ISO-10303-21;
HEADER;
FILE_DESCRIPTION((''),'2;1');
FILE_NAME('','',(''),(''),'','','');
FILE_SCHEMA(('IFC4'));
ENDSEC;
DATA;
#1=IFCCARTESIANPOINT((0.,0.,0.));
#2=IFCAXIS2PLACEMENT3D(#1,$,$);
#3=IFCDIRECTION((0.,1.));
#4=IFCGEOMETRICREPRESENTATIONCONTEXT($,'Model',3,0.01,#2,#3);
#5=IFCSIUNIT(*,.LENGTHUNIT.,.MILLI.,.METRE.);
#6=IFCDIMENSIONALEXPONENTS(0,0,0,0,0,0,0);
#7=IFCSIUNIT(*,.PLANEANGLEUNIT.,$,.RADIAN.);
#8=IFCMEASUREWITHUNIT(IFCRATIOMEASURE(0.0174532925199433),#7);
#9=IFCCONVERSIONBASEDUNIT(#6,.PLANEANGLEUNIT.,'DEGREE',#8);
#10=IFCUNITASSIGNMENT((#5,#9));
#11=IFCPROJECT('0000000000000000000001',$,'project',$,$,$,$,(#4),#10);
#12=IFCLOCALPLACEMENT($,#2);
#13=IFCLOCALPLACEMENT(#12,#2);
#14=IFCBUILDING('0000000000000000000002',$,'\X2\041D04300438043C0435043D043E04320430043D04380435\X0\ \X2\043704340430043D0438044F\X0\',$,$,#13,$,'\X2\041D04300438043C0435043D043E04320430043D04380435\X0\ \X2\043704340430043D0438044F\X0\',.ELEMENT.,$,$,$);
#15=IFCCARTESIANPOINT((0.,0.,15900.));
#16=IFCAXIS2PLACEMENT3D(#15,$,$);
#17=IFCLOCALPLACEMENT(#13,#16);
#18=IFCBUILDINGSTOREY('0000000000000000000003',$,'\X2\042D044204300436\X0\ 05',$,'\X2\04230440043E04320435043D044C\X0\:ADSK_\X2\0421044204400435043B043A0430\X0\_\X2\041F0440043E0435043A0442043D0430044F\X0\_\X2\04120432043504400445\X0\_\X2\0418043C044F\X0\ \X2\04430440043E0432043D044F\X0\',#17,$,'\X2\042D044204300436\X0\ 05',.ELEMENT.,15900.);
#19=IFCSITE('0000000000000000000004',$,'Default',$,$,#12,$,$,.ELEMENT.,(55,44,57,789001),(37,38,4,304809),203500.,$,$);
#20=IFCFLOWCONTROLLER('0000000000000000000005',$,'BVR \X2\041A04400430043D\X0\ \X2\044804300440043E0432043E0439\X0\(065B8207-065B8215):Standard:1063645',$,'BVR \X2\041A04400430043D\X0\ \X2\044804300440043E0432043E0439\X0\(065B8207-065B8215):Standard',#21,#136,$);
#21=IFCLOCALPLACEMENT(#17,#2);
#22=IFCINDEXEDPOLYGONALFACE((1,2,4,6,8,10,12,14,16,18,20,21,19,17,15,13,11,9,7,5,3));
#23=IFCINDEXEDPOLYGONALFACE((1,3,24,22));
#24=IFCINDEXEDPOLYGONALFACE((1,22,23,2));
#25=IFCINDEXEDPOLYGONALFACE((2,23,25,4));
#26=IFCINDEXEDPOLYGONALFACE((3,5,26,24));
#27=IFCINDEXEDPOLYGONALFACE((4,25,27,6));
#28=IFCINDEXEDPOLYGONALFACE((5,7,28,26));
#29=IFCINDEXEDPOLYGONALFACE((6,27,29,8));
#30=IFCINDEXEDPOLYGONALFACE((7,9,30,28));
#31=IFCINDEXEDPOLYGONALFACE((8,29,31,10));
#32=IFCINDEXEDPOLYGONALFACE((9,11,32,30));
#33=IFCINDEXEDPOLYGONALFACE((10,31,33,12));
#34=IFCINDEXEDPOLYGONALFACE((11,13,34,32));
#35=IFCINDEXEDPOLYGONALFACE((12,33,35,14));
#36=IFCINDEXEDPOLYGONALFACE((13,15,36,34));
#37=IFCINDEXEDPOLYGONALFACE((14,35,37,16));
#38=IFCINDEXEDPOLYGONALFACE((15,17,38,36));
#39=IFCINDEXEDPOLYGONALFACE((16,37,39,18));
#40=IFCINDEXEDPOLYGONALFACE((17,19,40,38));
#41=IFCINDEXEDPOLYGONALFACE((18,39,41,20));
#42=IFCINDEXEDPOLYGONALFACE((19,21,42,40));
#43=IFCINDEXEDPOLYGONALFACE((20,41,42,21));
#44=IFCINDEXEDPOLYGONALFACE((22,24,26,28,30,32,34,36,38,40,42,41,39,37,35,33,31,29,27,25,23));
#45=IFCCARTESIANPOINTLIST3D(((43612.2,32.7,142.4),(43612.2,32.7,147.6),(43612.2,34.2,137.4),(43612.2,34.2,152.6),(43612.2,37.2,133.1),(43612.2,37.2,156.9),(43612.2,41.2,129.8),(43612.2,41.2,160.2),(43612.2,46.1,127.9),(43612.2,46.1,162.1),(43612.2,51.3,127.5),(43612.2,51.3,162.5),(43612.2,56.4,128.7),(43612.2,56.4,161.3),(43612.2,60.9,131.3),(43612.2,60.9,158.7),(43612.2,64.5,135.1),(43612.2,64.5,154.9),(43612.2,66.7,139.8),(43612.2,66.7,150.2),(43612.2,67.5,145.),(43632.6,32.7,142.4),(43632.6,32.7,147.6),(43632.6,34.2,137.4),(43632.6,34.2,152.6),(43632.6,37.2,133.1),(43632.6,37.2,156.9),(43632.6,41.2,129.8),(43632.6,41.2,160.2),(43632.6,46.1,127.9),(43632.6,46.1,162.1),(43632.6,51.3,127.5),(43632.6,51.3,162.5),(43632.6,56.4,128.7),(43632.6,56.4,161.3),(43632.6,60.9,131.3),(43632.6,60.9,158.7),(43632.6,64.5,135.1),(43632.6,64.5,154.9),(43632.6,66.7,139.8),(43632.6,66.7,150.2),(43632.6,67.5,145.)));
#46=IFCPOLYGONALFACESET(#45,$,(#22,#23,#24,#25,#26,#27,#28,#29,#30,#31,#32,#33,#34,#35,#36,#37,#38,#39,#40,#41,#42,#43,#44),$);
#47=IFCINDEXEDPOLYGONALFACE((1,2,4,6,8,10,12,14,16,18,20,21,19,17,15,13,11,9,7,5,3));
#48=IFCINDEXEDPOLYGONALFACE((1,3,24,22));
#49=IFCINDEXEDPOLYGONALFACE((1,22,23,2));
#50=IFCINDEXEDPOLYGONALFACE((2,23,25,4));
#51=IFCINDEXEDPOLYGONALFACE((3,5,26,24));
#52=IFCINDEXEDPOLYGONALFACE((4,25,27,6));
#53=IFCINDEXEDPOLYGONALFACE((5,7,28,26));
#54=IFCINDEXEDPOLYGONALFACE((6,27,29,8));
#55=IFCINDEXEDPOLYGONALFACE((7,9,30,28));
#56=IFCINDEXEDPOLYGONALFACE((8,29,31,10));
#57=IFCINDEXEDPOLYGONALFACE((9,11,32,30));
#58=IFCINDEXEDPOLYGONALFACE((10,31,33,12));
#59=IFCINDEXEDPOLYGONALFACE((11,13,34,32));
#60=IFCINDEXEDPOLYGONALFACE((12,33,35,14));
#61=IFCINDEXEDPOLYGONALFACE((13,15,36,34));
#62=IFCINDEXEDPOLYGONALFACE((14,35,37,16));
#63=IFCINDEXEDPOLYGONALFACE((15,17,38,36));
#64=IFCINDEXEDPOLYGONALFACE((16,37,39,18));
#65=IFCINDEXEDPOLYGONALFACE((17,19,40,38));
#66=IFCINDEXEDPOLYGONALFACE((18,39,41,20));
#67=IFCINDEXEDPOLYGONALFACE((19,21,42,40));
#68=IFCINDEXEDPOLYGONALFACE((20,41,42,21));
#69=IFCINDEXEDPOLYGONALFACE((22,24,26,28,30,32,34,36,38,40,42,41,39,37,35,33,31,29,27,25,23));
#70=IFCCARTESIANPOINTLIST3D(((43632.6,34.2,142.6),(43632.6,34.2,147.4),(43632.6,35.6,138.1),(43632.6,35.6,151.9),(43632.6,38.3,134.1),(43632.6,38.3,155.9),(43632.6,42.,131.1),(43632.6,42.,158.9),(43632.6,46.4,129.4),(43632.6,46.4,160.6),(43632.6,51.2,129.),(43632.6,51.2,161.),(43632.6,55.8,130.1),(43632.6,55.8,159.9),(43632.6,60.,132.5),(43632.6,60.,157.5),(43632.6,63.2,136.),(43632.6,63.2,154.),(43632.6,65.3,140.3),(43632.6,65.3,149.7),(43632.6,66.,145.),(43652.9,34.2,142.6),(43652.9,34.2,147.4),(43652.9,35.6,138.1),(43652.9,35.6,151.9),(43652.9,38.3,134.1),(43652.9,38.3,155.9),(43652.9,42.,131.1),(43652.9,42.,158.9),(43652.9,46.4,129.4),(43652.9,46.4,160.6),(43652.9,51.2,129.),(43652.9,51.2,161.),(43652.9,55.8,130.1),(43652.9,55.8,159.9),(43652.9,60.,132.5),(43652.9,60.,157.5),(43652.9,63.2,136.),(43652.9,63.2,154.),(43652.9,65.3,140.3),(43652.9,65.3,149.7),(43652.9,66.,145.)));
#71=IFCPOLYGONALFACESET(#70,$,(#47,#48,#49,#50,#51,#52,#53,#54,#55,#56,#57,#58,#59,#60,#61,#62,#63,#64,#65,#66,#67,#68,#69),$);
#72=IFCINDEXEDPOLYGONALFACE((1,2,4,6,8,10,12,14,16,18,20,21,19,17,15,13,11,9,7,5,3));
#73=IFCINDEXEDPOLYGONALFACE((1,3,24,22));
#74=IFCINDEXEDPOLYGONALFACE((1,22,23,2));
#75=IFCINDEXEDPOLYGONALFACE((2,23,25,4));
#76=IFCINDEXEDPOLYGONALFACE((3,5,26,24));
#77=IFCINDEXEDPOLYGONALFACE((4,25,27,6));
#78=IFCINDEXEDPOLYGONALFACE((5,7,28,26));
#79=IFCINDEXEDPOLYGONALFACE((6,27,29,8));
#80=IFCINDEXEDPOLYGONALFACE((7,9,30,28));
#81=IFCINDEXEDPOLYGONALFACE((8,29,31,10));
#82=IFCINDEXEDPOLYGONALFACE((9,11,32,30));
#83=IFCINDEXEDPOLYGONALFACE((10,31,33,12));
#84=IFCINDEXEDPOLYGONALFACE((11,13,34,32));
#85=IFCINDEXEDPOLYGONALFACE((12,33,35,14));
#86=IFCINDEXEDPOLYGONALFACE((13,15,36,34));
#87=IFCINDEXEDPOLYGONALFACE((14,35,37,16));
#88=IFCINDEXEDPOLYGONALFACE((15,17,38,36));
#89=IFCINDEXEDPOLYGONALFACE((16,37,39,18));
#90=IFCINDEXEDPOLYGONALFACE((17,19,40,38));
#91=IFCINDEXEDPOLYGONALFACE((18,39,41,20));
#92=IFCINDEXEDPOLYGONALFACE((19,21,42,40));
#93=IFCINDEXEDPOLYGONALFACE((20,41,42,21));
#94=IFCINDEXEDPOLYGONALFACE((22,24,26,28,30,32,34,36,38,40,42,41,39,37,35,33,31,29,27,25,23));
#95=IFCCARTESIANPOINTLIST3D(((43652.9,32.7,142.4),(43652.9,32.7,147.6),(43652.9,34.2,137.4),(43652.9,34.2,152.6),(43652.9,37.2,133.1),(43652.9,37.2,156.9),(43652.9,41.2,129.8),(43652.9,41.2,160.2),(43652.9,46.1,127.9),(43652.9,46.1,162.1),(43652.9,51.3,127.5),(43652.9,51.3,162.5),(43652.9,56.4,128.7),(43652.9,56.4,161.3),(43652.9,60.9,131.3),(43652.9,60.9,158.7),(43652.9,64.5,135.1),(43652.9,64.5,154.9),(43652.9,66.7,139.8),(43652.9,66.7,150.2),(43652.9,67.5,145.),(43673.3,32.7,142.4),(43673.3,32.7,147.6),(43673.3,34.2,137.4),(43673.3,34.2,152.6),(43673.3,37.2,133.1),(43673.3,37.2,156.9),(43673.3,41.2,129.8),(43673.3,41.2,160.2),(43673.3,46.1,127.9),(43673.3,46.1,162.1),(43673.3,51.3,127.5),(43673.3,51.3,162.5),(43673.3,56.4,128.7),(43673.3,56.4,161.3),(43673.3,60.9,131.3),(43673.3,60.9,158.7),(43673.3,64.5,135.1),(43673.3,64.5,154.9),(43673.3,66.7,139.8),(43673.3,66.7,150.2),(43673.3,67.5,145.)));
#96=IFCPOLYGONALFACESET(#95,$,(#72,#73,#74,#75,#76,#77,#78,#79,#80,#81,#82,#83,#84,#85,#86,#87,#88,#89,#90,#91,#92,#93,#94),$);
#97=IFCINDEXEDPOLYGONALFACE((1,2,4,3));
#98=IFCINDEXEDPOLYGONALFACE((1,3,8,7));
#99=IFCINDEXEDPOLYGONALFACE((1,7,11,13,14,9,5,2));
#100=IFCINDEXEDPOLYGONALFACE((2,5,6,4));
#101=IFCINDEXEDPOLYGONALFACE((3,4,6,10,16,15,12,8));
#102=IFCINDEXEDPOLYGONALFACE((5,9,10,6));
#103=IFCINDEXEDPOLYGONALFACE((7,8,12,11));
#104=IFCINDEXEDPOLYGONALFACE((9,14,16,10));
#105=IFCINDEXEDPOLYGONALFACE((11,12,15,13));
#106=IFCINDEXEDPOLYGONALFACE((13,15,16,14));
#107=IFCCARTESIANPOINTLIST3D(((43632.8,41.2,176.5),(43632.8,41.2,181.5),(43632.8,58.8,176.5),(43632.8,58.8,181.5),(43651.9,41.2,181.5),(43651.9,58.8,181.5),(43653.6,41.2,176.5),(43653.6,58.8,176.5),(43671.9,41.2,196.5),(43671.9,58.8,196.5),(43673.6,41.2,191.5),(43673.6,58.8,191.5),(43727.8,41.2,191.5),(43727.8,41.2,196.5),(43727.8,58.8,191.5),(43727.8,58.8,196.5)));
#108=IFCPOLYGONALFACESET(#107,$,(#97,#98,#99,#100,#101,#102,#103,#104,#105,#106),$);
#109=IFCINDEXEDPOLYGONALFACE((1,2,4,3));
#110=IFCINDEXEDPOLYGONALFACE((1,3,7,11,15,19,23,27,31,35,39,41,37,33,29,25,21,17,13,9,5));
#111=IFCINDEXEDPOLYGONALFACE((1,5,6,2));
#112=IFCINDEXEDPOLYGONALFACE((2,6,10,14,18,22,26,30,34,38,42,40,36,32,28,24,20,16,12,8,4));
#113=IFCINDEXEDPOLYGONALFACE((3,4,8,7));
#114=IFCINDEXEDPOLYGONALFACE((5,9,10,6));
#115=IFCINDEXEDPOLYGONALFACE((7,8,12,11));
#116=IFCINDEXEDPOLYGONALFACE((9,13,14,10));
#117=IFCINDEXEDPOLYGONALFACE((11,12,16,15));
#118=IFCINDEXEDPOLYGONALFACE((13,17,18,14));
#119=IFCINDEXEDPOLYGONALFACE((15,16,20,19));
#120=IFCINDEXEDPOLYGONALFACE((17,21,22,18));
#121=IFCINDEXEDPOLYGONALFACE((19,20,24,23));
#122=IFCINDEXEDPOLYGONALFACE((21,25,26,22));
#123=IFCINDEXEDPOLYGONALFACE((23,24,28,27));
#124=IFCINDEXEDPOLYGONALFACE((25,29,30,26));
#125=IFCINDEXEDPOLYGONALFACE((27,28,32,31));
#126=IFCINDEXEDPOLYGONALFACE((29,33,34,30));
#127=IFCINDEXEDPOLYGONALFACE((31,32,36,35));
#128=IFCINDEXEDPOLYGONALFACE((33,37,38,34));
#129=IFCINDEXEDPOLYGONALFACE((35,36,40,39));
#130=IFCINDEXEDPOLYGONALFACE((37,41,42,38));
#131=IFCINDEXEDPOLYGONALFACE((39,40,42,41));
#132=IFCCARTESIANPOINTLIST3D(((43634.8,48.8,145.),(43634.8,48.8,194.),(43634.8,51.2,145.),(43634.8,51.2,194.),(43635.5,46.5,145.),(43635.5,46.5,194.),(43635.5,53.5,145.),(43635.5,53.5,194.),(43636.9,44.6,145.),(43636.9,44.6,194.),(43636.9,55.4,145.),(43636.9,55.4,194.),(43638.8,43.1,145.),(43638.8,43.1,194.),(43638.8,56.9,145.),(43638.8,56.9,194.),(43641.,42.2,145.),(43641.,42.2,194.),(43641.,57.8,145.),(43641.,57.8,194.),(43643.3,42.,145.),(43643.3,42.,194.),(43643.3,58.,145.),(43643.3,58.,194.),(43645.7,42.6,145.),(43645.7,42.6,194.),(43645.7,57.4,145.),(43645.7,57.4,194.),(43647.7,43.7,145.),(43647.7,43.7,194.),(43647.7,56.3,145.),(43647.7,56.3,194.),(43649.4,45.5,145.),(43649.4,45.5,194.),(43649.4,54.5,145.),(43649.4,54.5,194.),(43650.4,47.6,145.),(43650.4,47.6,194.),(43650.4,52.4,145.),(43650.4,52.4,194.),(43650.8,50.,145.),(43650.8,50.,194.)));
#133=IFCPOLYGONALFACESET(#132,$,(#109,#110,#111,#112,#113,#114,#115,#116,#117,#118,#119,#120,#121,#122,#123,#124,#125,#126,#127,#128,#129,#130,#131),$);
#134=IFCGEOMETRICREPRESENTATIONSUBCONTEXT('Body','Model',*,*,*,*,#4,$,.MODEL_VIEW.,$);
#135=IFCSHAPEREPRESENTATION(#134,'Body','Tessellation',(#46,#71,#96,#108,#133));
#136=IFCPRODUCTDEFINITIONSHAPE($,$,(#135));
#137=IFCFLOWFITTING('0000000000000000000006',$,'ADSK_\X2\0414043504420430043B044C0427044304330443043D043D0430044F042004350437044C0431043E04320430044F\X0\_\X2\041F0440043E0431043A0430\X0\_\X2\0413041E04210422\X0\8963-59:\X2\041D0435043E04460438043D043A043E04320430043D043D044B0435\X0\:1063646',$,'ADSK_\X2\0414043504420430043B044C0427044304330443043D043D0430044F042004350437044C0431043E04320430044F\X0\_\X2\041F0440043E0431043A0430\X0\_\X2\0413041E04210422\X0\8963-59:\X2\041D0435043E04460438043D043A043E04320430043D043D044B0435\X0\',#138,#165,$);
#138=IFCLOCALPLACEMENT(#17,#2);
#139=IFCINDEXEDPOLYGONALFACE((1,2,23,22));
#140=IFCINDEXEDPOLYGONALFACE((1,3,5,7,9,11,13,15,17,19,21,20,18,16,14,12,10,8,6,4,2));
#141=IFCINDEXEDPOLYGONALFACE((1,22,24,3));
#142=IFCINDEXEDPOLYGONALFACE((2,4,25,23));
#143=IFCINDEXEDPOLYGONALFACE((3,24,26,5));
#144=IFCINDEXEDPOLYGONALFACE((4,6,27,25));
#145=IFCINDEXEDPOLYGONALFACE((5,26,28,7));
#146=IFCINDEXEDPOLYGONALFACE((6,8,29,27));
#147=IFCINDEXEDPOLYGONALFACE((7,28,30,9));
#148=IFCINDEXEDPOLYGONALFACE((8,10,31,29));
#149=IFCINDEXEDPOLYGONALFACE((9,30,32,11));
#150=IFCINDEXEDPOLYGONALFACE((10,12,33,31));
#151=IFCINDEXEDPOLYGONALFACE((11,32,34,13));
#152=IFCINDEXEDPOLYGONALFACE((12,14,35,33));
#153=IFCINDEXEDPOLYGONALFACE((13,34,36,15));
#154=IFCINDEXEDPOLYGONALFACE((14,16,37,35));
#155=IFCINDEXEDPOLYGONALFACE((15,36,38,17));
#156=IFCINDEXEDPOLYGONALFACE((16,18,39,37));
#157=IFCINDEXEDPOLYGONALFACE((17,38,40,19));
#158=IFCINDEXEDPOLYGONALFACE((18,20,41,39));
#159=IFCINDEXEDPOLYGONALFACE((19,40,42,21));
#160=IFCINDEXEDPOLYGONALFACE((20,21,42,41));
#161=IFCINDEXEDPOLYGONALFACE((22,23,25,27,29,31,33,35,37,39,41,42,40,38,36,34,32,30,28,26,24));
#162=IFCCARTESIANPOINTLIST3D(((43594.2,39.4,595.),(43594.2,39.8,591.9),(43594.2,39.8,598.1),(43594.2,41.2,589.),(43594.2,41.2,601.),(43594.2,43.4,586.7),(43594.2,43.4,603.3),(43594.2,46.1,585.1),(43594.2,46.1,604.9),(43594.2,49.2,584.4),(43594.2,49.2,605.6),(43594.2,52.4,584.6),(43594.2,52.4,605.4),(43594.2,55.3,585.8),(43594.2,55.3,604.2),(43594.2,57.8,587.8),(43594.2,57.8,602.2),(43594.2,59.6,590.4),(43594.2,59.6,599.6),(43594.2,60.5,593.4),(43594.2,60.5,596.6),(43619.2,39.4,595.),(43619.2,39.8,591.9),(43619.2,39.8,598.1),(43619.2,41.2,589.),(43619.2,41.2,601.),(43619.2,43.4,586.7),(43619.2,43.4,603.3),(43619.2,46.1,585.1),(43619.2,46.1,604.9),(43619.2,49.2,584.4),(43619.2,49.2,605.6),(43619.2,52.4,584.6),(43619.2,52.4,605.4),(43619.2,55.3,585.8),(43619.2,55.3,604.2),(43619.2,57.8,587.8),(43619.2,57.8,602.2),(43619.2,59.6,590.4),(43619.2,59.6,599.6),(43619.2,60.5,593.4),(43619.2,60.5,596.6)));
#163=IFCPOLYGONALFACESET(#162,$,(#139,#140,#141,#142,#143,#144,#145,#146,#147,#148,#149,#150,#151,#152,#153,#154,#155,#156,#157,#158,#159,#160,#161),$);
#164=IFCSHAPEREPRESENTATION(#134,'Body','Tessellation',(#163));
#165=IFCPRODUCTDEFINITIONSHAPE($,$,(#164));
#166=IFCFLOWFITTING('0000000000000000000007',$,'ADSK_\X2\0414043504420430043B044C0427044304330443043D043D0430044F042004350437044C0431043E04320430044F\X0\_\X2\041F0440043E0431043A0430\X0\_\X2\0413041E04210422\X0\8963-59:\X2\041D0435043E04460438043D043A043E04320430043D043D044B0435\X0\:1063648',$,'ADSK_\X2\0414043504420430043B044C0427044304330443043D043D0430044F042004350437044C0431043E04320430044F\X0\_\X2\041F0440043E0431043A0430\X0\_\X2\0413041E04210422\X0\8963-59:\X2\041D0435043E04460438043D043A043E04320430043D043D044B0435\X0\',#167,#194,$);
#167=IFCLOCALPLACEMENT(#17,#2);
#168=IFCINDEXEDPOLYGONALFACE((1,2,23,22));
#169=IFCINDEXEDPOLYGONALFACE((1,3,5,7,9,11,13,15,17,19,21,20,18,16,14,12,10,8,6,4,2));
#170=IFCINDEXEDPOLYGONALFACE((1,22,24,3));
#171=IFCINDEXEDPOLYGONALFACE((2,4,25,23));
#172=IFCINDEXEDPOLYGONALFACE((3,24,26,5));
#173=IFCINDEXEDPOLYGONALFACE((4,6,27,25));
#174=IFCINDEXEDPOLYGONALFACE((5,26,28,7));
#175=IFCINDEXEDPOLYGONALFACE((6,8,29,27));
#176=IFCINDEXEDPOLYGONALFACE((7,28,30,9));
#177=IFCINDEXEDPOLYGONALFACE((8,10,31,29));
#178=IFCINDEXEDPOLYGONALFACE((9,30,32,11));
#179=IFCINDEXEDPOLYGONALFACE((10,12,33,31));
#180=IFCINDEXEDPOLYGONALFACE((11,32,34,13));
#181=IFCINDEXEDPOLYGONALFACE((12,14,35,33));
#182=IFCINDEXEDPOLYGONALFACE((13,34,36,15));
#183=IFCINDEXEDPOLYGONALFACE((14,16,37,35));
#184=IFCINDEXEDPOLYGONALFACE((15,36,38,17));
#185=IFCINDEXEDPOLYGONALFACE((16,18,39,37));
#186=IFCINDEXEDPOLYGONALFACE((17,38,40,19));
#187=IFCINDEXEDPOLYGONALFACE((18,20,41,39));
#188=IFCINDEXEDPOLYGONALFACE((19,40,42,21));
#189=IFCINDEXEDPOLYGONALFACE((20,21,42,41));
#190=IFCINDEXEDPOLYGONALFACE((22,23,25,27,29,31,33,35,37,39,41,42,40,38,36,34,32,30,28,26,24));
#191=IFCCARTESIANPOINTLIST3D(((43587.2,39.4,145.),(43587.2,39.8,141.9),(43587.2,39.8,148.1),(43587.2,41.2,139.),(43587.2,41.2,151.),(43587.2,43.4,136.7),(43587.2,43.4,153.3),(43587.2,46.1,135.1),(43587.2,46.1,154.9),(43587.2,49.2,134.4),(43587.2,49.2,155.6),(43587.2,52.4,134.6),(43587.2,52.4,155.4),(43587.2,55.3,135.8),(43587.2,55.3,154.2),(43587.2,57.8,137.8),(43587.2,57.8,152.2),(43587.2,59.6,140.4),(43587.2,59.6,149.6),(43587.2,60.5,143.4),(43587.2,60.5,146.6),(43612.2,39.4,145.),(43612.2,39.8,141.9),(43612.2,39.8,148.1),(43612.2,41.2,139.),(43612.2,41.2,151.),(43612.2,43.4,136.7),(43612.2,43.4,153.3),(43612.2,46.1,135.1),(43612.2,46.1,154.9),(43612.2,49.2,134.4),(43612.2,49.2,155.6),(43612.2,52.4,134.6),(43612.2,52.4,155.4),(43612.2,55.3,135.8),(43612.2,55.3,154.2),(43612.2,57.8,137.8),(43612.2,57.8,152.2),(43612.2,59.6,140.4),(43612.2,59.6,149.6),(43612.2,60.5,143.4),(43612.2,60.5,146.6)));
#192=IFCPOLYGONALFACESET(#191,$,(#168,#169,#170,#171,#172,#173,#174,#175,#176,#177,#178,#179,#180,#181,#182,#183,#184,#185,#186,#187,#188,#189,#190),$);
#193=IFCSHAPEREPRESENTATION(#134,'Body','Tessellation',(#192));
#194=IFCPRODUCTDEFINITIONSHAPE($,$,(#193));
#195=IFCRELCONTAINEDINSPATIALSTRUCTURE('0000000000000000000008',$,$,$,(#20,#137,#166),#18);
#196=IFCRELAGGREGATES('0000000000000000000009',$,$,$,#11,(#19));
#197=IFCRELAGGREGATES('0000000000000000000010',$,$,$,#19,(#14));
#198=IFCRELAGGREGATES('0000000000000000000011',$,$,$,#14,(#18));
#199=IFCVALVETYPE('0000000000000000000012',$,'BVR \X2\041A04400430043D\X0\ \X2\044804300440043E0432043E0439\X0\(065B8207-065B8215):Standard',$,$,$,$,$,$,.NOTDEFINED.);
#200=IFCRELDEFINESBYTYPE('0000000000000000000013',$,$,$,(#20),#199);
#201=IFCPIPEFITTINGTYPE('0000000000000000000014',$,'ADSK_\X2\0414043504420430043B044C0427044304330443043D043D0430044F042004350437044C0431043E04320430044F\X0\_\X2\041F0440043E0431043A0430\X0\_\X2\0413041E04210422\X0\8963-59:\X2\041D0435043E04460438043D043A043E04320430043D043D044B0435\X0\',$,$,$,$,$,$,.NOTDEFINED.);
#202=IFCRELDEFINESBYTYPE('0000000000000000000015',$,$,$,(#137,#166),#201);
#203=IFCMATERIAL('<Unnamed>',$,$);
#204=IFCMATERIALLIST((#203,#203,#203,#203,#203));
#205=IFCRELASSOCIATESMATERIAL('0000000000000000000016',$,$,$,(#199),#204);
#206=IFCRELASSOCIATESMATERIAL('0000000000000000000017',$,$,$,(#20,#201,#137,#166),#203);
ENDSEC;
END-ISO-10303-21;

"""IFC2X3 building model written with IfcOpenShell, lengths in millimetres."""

from ifc_helpers import new_model, entity, si_unit, converted_unit, direction, frame, origin, origin_2d_with_axis, place, context, subcontext, project, spatial, polyline, circle, outline, extrude, source, transform, mapped, material, material_list, type_object, type_shapes, element, save


model = new_model("IFC2X3")

# Units and contexts
model_context = context("Model", 3, precision=0.01, world=origin(), true_north=direction((0.0, 1.0)))
body_context = subcontext(model_context, "Body", "Model", "MODEL_VIEW")
ifc_project = project(units=[si_unit("LENGTHUNIT", "METRE", prefix="MILLI"), converted_unit("PLANEANGLEUNIT", "DEGREE", entity("IfcRatioMeasure", 0.0174532925199433), si_unit("PLANEANGLEUNIT", "RADIAN"), dimensions=[0, 0, 0, 0, 0, 0, 0])], contexts=[model_context])

# Site, building, storey
site_placement = place(None, origin())
site = spatial("IfcSite", under=ifc_project, at=site_placement, Name="Default", CompositionType="ELEMENT", RefLatitude=(55, 44, 57, 789001), RefLongitude=(37, 38, 4, 304809), RefElevation=203500.0)
building_placement = place(site_placement, origin())
building = spatial("IfcBuilding", under=site, at=building_placement, Name="Наименование здания", LongName="Наименование здания", CompositionType="ELEMENT")
storey_placement = place(building_placement, frame((0.0, 0.0, 15900.0)))
storey = spatial("IfcBuildingStorey", under=building, at=storey_placement, Name="Этаж 05", ObjectType="Уровень:ADSK_Стрелка_Проектная_Вверх_Имя уровня", LongName="Этаж 05", CompositionType="ELEMENT", Elevation=15900.0)

# Flow controller
ifc_material = material(Name="<Unnamed>")
ifc_material_list_1 = material_list([ifc_material, ifc_material, ifc_material, ifc_material, ifc_material])
valve_type_1 = type_object("IfcValveType", Name="BVR Кран шаровой(065B8207-065B8215):Standard", PredefinedType="NOTDEFINED", material=ifc_material_list_1)
shared_shape_1 = source(origin(), body_context, "Body", "SweptSolid", [
    extrude(circle(Radius=17.5, at=origin_2d_with_axis()), frame((-30.5, 0.0, 0.0), z_axis=(1.0, 0.0, 0.0), x_axis=(0.0, 1.0, 0.0)), (0.0, 0.0, 1.0), 20.3),
    extrude(circle(Radius=16.0, at=origin_2d_with_axis()), frame((-10.2, 0.0, 0.0), z_axis=(1.0, 0.0, 0.0), x_axis=(0.0, 1.0, 0.0)), (0.0, 0.0, 1.0), 20.3),
    extrude(circle(Radius=17.5, at=origin_2d_with_axis()), frame((10.2, 0.0, 0.0), z_axis=(1.0, 0.0, 0.0), x_axis=(0.0, 1.0, 0.0)), (0.0, 0.0, 1.0), 20.3),
    extrude(outline(polyline([(-38.8, -5.0), (-38.8, -10.0), (-17.9, -10.0), (2.1, 5.0), (56.2, 5.0), (56.2, 10.0), (0.4, 10.0), (-19.6, -5.0), (-38.8, -5.0)])), frame((28.8, -8.8, 41.5), z_axis=(0.0, -1.0, 0.0), x_axis=(1.0, 0.0, 0.0)), (0.0, 0.0, -1.0), 17.5),
    extrude(circle(Radius=8.0, at=origin_2d_with_axis()), origin(), (0.0, 0.0, 1.0), 49.0),
])
type_shapes(valve_type_1, [shared_shape_1])
flow_controller_1_placement = place(storey_placement, frame((43642.8, 50.0, 145.0)))
element("IfcFlowController", 1, at=flow_controller_1_placement, inside=storey, type_object=valve_type_1, material=ifc_material, Name="BVR Кран шаровой(065B8207-065B8215):Standard:1063645", ObjectType="BVR Кран шаровой(065B8207-065B8215):Standard", context=body_context, shape_type="MappedRepresentation", body=[
    mapped(shared_shape_1, transform((0.0, 0.0, 0.0), scale=1.0)),
])

# Flow fittings
pipe_fitting_type = type_object("IfcPipeFittingType", Name="ADSK_ДетальЧугуннаяРезьбовая_Пробка_ГОСТ8963-59:Неоцинкованные", PredefinedType="NOTDEFINED", material=ifc_material)
shared_shape_2 = source(origin(), body_context, "Body", "SweptSolid", [
    extrude(circle(Radius=10.7, at=origin_2d_with_axis()), frame((0.0, 0.0, 0.0), z_axis=(1.0, 0.0, 0.0), x_axis=(0.0, 1.0, 0.0)), (0.0, 0.0, 1.0), 25.0),
])
type_shapes(pipe_fitting_type, [shared_shape_2])
for number, where, z_axis, x_axis, name in (
    (2, (43619.2, 50.0, 595.0), (0.0, 0.0, 1.0), (-1.0, 0.0, 0.0), "ADSK_ДетальЧугуннаяРезьбовая_Пробка_ГОСТ8963-59:Неоцинкованные:1063646"),
    (3, (43612.2, 50.0, 145.0), (0.0, 0.0, 1.0), (-1.0, 0.0, 0.0), "ADSK_ДетальЧугуннаяРезьбовая_Пробка_ГОСТ8963-59:Неоцинкованные:1063648"),
):
    element("IfcFlowFitting", number, at=place(storey_placement, frame(where, z_axis=z_axis, x_axis=x_axis)), inside=storey, type_object=pipe_fitting_type, material=ifc_material, Name=name, ObjectType="ADSK_ДетальЧугуннаяРезьбовая_Пробка_ГОСТ8963-59:Неоцинкованные", context=body_context, shape_type="MappedRepresentation", body=[
        mapped(shared_shape_2, transform((0.0, 0.0, 0.0), scale=1.0)),
    ])

save(model, "model.ifc")
